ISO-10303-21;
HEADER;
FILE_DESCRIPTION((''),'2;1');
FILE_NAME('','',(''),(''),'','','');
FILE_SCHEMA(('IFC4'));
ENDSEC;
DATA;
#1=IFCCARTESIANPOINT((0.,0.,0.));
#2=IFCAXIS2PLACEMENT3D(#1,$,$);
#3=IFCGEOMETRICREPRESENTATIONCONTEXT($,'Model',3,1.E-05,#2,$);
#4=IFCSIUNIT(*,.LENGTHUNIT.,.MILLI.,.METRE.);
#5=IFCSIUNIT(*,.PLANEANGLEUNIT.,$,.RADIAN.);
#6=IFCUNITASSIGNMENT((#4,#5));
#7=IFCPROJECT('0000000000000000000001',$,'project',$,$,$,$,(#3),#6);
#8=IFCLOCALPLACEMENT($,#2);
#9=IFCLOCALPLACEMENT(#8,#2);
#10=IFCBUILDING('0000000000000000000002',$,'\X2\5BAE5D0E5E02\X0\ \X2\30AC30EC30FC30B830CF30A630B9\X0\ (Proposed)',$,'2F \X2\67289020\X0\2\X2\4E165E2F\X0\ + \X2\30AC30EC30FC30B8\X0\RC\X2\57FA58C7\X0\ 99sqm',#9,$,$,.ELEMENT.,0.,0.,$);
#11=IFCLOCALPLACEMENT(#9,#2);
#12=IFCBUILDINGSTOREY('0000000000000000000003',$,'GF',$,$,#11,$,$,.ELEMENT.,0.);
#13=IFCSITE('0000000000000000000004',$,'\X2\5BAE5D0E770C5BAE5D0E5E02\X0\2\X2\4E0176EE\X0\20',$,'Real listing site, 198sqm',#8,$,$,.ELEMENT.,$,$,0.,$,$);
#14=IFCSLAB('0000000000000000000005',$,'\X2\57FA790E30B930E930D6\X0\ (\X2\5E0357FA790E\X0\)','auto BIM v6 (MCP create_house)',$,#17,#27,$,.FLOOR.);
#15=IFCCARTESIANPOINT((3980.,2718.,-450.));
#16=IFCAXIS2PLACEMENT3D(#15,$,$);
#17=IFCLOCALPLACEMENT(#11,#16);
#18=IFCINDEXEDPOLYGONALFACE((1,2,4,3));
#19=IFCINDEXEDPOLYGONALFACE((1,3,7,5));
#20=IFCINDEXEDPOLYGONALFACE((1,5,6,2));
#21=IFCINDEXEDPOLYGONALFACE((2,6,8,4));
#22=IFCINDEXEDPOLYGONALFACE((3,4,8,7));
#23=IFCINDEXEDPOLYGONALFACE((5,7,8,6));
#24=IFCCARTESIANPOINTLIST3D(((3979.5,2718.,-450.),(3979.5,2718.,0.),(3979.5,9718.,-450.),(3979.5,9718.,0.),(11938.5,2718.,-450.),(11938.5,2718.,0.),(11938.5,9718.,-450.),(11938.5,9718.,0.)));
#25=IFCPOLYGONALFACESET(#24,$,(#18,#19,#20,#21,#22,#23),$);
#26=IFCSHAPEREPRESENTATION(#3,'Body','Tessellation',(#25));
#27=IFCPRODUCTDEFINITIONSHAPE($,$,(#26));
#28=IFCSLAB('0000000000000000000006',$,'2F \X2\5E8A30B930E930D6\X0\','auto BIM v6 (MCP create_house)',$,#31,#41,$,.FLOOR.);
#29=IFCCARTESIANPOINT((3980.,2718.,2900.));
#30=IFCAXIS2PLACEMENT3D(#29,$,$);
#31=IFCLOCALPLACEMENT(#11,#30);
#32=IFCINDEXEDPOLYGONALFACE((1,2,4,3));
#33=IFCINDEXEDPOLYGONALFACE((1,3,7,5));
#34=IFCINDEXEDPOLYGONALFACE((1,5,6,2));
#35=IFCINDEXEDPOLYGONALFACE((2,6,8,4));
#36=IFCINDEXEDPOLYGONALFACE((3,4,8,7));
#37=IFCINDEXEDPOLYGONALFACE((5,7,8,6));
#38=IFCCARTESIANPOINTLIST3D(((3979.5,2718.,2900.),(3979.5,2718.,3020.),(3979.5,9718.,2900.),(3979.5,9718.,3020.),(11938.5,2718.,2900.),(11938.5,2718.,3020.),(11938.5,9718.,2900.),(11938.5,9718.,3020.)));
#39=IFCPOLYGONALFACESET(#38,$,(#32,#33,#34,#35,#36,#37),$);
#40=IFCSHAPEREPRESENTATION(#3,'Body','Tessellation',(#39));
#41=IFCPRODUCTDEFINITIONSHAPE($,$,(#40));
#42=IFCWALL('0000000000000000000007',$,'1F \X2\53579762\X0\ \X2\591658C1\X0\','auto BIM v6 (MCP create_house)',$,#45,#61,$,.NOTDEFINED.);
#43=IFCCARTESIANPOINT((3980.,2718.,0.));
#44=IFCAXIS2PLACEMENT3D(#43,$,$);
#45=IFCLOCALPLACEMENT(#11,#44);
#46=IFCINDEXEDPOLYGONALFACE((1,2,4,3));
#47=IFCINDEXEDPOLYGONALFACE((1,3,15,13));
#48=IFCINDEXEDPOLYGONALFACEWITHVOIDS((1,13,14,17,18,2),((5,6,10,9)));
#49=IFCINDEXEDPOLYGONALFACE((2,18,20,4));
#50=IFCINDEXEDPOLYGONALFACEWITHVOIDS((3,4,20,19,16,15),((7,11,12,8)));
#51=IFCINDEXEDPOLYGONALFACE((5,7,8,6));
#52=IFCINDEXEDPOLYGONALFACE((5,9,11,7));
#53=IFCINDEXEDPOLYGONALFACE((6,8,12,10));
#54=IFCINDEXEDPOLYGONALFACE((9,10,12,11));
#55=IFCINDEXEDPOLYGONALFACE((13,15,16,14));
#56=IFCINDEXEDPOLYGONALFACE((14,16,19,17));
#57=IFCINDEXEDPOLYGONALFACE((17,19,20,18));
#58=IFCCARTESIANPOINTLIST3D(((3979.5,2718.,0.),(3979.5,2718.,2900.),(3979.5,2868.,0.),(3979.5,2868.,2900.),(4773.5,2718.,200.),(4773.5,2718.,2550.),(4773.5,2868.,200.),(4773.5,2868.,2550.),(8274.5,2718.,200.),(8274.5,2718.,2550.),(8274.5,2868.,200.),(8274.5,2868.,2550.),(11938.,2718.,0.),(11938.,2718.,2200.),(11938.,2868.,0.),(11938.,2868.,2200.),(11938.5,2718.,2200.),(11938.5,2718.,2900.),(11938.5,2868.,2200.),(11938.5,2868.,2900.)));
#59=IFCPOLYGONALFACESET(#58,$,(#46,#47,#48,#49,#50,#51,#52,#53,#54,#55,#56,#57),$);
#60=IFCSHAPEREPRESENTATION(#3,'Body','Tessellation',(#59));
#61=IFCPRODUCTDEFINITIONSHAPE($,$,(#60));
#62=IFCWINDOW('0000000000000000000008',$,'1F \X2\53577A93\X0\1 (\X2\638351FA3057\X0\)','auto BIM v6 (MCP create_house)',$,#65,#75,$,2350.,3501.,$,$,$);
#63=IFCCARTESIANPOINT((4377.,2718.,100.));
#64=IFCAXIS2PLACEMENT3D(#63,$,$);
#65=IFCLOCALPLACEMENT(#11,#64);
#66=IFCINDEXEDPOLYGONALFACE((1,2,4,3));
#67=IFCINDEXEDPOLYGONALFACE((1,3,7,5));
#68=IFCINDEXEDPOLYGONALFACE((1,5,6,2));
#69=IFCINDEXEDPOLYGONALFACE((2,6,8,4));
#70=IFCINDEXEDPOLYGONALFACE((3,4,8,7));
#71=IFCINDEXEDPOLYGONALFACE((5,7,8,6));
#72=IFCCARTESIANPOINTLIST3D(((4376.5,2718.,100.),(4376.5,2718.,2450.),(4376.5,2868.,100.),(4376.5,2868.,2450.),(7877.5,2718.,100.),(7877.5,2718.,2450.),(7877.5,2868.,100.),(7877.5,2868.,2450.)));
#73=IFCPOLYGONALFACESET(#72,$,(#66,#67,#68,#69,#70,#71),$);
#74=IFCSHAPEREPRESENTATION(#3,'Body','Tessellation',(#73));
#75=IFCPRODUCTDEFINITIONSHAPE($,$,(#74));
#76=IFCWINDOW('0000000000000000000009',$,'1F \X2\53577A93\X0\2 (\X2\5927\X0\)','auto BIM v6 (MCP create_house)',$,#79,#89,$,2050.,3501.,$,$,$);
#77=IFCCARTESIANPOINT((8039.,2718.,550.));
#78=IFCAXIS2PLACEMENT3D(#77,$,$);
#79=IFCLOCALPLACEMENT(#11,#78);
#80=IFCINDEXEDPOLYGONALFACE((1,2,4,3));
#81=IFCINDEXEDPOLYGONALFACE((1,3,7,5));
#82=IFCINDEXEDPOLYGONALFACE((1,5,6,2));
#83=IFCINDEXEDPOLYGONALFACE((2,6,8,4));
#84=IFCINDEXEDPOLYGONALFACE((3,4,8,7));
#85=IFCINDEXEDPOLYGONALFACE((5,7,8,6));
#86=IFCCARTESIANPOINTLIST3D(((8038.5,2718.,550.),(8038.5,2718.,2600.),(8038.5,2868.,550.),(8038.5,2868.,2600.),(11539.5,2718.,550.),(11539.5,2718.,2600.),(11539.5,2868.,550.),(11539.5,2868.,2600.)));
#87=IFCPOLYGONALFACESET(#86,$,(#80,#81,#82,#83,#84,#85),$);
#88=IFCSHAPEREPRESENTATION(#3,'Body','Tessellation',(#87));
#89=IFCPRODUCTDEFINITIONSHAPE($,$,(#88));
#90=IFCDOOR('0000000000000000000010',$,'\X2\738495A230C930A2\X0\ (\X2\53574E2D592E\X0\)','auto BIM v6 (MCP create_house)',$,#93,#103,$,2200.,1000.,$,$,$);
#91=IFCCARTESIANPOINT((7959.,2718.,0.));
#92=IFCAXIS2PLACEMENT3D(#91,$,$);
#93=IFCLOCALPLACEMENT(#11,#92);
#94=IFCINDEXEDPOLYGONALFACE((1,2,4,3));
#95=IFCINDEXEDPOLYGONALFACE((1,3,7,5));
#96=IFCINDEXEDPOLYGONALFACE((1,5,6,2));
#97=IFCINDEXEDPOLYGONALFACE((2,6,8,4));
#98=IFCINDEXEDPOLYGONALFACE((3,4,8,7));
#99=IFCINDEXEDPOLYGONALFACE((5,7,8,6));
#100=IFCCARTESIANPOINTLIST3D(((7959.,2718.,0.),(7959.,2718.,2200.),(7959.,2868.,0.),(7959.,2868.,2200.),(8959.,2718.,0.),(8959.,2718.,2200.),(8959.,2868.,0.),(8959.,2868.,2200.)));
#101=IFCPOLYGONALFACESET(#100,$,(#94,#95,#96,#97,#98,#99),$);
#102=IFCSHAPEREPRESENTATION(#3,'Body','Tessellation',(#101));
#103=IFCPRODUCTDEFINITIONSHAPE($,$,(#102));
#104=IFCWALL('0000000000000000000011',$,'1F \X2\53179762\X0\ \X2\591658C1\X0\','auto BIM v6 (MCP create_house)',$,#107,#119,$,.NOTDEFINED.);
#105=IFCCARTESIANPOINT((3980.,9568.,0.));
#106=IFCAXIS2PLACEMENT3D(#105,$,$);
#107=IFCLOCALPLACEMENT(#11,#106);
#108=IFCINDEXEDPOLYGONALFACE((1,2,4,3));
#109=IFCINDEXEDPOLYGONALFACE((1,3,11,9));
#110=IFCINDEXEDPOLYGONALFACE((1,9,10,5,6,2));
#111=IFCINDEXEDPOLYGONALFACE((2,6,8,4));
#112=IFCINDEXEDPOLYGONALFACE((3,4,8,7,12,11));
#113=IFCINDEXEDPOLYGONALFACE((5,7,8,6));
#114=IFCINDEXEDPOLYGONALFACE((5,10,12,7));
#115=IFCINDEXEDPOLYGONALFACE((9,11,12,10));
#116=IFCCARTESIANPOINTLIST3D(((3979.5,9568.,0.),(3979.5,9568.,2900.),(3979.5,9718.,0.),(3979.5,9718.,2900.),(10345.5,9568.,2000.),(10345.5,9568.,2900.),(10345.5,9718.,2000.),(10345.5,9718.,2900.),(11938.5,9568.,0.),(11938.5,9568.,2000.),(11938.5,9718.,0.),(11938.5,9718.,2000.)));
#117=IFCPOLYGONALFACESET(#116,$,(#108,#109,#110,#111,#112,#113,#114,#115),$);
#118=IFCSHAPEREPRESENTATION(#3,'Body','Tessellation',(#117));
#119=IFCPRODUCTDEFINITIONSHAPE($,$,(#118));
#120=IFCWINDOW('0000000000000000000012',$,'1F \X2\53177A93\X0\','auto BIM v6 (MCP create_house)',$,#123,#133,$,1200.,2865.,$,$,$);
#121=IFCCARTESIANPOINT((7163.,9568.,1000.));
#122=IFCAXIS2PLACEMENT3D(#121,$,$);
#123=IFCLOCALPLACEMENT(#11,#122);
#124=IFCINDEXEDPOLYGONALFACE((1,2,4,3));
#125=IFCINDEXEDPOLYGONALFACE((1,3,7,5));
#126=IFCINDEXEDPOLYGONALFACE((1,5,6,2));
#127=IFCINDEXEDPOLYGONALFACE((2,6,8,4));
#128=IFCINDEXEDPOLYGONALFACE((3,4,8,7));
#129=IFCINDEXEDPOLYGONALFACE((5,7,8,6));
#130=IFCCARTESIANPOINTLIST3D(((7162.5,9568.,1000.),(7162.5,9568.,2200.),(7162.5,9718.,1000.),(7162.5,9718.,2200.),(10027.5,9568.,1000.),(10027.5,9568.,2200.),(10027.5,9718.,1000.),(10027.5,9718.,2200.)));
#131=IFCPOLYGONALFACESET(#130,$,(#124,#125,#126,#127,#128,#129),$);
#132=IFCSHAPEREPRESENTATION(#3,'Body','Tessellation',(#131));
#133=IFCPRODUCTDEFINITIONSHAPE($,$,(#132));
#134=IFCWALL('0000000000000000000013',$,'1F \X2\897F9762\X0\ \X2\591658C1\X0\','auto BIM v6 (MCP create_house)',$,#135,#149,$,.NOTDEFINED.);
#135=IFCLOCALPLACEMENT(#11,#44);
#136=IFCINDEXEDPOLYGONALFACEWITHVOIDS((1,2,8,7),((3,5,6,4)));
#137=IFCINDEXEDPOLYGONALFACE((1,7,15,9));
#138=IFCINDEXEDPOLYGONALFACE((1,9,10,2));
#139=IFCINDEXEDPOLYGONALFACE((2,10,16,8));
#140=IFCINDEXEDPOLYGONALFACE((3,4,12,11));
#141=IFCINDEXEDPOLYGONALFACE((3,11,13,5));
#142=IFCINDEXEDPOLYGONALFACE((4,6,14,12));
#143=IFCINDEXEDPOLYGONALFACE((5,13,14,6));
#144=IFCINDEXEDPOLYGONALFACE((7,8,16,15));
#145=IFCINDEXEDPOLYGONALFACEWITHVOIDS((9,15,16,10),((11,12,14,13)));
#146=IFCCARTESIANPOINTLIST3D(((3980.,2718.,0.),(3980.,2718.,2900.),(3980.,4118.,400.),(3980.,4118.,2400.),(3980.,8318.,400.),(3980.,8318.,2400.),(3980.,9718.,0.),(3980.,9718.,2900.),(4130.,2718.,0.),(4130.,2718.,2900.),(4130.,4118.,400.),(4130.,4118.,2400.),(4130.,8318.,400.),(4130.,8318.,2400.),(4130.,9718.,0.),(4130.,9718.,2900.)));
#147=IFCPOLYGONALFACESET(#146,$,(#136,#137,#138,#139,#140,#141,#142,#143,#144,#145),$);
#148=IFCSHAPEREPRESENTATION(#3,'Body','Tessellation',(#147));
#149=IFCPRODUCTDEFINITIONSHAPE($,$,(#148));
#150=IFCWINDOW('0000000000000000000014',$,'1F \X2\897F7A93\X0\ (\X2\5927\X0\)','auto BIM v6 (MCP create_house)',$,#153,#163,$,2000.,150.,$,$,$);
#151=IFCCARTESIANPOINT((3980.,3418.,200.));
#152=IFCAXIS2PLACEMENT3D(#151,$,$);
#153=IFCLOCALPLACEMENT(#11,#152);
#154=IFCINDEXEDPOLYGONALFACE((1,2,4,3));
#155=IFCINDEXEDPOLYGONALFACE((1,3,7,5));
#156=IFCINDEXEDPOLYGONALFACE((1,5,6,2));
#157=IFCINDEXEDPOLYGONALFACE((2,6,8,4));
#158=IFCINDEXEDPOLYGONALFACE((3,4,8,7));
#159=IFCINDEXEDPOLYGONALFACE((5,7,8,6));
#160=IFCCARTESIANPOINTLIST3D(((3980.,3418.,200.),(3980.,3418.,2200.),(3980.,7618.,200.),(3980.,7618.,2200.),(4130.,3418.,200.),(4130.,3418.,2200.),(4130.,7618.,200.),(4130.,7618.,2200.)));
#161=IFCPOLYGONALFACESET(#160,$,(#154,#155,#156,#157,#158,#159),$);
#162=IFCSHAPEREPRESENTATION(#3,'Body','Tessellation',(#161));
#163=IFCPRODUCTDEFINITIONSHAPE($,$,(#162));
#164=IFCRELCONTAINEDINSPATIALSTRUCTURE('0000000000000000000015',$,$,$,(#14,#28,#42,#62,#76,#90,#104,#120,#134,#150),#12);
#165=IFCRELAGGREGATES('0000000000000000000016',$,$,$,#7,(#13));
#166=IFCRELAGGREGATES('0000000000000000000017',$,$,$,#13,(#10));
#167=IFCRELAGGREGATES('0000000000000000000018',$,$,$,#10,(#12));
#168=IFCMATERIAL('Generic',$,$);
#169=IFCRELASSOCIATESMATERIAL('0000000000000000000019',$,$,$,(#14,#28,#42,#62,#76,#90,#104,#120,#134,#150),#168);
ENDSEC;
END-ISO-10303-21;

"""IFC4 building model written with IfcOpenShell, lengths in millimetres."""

from ifc_helpers import new_model, si_unit, frame, frame_2d, origin, place, context, project, spatial, rectangle, extrude, material, element, fill, save


model = new_model("IFC4")

# Units and contexts
model_context = context("Model", 3, precision=1e-05, world=origin())
ifc_project = project(units=[si_unit("LENGTHUNIT", "METRE", prefix="MILLI"), si_unit("PLANEANGLEUNIT", "RADIAN")], contexts=[model_context])

# Site, building, storey
site_placement = place(None, origin())
site = spatial("IfcSite", under=ifc_project, at=site_placement, Name="宮崎県宮崎市2丁目20", ObjectType="Real listing site, 198sqm", CompositionType="ELEMENT", RefElevation=0.0)
building_placement = place(site_placement, origin())
building = spatial("IfcBuilding", under=site, at=building_placement, Name="宮崎市 ガレージハウス (Proposed)", ObjectType="2F 木造2世帯 + ガレージRC基壇 99sqm", CompositionType="ELEMENT", ElevationOfRefHeight=0.0, ElevationOfTerrain=0.0)
storey_placement = place(building_placement, origin())
storey = spatial("IfcBuildingStorey", under=building, at=storey_placement, Name="GF", CompositionType="ELEMENT", Elevation=0.0)

# Slabs
ifc_material = material(Name="Generic")
slab_1_placement = place(storey_placement, frame((3980.0, 2718.0, -450.0)))
element("IfcSlab", 1, at=slab_1_placement, inside=storey, material=ifc_material, Name="基礎スラブ (布基礎)", Description="auto BIM v6 (MCP create_house)", PredefinedType="FLOOR", context=model_context, shape_type="SweptSolid", body=[
    extrude(rectangle(XDim=7959.0, YDim=7000.0, at=frame_2d((3979.0, 3500.0))), frame((3980.0, 2718.0, -450.0)), (0.0, 0.0, 1.0), 450.0),
])
slab_2_placement = place(storey_placement, frame((3980.0, 2718.0, 2900.0)))
element("IfcSlab", 2, at=slab_2_placement, inside=storey, material=ifc_material, Name="2F 床スラブ", Description="auto BIM v6 (MCP create_house)", PredefinedType="FLOOR", context=model_context, shape_type="SweptSolid", body=[
    extrude(rectangle(XDim=7959.0, YDim=7000.0, at=frame_2d((3979.0, 3500.0))), frame((3980.0, 2718.0, 2900.0)), (0.0, 0.0, 1.0), 120.0),
])

# Wall, openings, windows, door
wall_1_placement = place(storey_placement, frame((3980.0, 2718.0, 0.0)))
wall_1 = element("IfcWall", 3, at=wall_1_placement, inside=storey, material=ifc_material, Name="1F 南面 外壁", Description="auto BIM v6 (MCP create_house)", PredefinedType="NOTDEFINED", context=model_context, shape_type="SweptSolid", body=[
    extrude(rectangle(XDim=7959.0, YDim=150.0, at=frame_2d((3979.0, 75.0))), frame((3980.0, 2718.0, 0.0)), (0.0, 0.0, 1.0), 2900.0),
])
opening_1_placement = place(storey_placement, frame((4377.0, 2718.0, 100.0)))
opening_1 = element("IfcOpeningElement", 4, at=opening_1_placement, cuts=wall_1, PredefinedType="NOTDEFINED", context=model_context, shape_type="SweptSolid", body=[
    extrude(rectangle(XDim=3501.0, YDim=150.0, at=frame_2d((1750.0, 75.0))), frame((4377.0, 2718.0, 100.0)), (0.0, 0.0, 1.0), 2350.0),
])
opening_2_placement = place(storey_placement, frame((8039.0, 2718.0, 550.0)))
opening_2 = element("IfcOpeningElement", 5, at=opening_2_placement, cuts=wall_1, PredefinedType="NOTDEFINED", context=model_context, shape_type="SweptSolid", body=[
    extrude(rectangle(XDim=3501.0, YDim=150.0, at=frame_2d((1750.0, 75.0))), frame((8039.0, 2718.0, 550.0)), (0.0, 0.0, 1.0), 2050.0),
])
opening_3_placement = place(storey_placement, frame((7959.0, 2718.0, 0.0)))
opening_3 = element("IfcOpeningElement", 6, at=opening_3_placement, cuts=wall_1, PredefinedType="NOTDEFINED", context=model_context, shape_type="SweptSolid", body=[
    extrude(rectangle(XDim=1000.0, YDim=150.0, at=frame_2d((500.0, 75.0))), frame((7959.0, 2718.0, 0.0)), (0.0, 0.0, 1.0), 2200.0),
])
window_1_placement = place(storey_placement, frame((4377.0, 2718.0, 100.0)))
window_1 = element("IfcWindow", 7, at=window_1_placement, inside=storey, material=ifc_material, Name="1F 南窓1 (掃出し)", Description="auto BIM v6 (MCP create_house)", OverallHeight=2350.0, OverallWidth=3501.0, context=model_context, shape_type="SweptSolid", body=[
    extrude(rectangle(XDim=3501.0, YDim=150.0, at=frame_2d((1750.0, 75.0))), frame((4377.0, 2718.0, 100.0)), (0.0, 0.0, 1.0), 2350.0),
])
fill(opening_1, window_1)
window_2_placement = place(storey_placement, frame((8039.0, 2718.0, 550.0)))
window_2 = element("IfcWindow", 8, at=window_2_placement, inside=storey, material=ifc_material, Name="1F 南窓2 (大)", Description="auto BIM v6 (MCP create_house)", OverallHeight=2050.0, OverallWidth=3501.0, context=model_context, shape_type="SweptSolid", body=[
    extrude(rectangle(XDim=3501.0, YDim=150.0, at=frame_2d((1750.0, 75.0))), frame((8039.0, 2718.0, 550.0)), (0.0, 0.0, 1.0), 2050.0),
])
fill(opening_2, window_2)
door_placement = place(storey_placement, frame((7959.0, 2718.0, 0.0)))
door = element("IfcDoor", 9, at=door_placement, inside=storey, material=ifc_material, Name="玄関ドア (南中央)", Description="auto BIM v6 (MCP create_house)", OverallHeight=2200.0, OverallWidth=1000.0, context=model_context, shape_type="SweptSolid", body=[
    extrude(rectangle(XDim=1000.0, YDim=150.0, at=frame_2d((500.0, 75.0))), frame((7959.0, 2718.0, 0.0)), (0.0, 0.0, 1.0), 2200.0),
])
fill(opening_3, door)

# Walls, openings, windows
wall_2_placement = place(storey_placement, frame((3980.0, 9568.0, 0.0)))
wall_2 = element("IfcWall", 10, at=wall_2_placement, inside=storey, material=ifc_material, Name="1F 北面 外壁", Description="auto BIM v6 (MCP create_house)", PredefinedType="NOTDEFINED", context=model_context, shape_type="SweptSolid", body=[
    extrude(rectangle(XDim=7959.0, YDim=150.0, at=frame_2d((3979.0, 75.0))), frame((3980.0, 9568.0, 0.0)), (0.0, 0.0, 1.0), 2900.0),
])
opening_4_placement = place(storey_placement, frame((7163.0, 9568.0, 1000.0)))
opening_4 = element("IfcOpeningElement", 11, at=opening_4_placement, cuts=wall_2, PredefinedType="NOTDEFINED", context=model_context, shape_type="SweptSolid", body=[
    extrude(rectangle(XDim=2865.0, YDim=150.0, at=frame_2d((1432.0, 75.0))), frame((7163.0, 9568.0, 1000.0)), (0.0, 0.0, 1.0), 1200.0),
])
window_3_placement = place(storey_placement, frame((7163.0, 9568.0, 1000.0)))
window_3 = element("IfcWindow", 12, at=window_3_placement, inside=storey, material=ifc_material, Name="1F 北窓", Description="auto BIM v6 (MCP create_house)", OverallHeight=1200.0, OverallWidth=2865.0, context=model_context, shape_type="SweptSolid", body=[
    extrude(rectangle(XDim=2865.0, YDim=150.0, at=frame_2d((1432.0, 75.0))), frame((7163.0, 9568.0, 1000.0)), (0.0, 0.0, 1.0), 1200.0),
])
fill(opening_4, window_3)
wall_3_placement = place(storey_placement, frame((3980.0, 2718.0, 0.0)))
wall_3 = element("IfcWall", 13, at=wall_3_placement, inside=storey, material=ifc_material, Name="1F 西面 外壁", Description="auto BIM v6 (MCP create_house)", PredefinedType="NOTDEFINED", context=model_context, shape_type="SweptSolid", body=[
    extrude(rectangle(XDim=150.0, YDim=7000.0, at=frame_2d((75.0, 3500.0))), frame((3980.0, 2718.0, 0.0)), (0.0, 0.0, 1.0), 2900.0),
])
opening_5_placement = place(storey_placement, frame((3980.0, 3418.0, 200.0)))
opening_5 = element("IfcOpeningElement", 14, at=opening_5_placement, cuts=wall_3, PredefinedType="NOTDEFINED", context=model_context, shape_type="SweptSolid", body=[
    extrude(rectangle(XDim=150.0, YDim=4200.0, at=frame_2d((75.0, 2100.0))), frame((3980.0, 3418.0, 200.0)), (0.0, 0.0, 1.0), 2000.0),
])
window_4_placement = place(storey_placement, frame((3980.0, 3418.0, 200.0)))
window_4 = element("IfcWindow", 15, at=window_4_placement, inside=storey, material=ifc_material, Name="1F 西窓 (大)", Description="auto BIM v6 (MCP create_house)", OverallHeight=2000.0, OverallWidth=150.0, context=model_context, shape_type="SweptSolid", body=[
    extrude(rectangle(XDim=150.0, YDim=4200.0, at=frame_2d((75.0, 2100.0))), frame((3980.0, 3418.0, 200.0)), (0.0, 0.0, 1.0), 2000.0),
])
fill(opening_5, window_4)

save(model, "model.ifc")
